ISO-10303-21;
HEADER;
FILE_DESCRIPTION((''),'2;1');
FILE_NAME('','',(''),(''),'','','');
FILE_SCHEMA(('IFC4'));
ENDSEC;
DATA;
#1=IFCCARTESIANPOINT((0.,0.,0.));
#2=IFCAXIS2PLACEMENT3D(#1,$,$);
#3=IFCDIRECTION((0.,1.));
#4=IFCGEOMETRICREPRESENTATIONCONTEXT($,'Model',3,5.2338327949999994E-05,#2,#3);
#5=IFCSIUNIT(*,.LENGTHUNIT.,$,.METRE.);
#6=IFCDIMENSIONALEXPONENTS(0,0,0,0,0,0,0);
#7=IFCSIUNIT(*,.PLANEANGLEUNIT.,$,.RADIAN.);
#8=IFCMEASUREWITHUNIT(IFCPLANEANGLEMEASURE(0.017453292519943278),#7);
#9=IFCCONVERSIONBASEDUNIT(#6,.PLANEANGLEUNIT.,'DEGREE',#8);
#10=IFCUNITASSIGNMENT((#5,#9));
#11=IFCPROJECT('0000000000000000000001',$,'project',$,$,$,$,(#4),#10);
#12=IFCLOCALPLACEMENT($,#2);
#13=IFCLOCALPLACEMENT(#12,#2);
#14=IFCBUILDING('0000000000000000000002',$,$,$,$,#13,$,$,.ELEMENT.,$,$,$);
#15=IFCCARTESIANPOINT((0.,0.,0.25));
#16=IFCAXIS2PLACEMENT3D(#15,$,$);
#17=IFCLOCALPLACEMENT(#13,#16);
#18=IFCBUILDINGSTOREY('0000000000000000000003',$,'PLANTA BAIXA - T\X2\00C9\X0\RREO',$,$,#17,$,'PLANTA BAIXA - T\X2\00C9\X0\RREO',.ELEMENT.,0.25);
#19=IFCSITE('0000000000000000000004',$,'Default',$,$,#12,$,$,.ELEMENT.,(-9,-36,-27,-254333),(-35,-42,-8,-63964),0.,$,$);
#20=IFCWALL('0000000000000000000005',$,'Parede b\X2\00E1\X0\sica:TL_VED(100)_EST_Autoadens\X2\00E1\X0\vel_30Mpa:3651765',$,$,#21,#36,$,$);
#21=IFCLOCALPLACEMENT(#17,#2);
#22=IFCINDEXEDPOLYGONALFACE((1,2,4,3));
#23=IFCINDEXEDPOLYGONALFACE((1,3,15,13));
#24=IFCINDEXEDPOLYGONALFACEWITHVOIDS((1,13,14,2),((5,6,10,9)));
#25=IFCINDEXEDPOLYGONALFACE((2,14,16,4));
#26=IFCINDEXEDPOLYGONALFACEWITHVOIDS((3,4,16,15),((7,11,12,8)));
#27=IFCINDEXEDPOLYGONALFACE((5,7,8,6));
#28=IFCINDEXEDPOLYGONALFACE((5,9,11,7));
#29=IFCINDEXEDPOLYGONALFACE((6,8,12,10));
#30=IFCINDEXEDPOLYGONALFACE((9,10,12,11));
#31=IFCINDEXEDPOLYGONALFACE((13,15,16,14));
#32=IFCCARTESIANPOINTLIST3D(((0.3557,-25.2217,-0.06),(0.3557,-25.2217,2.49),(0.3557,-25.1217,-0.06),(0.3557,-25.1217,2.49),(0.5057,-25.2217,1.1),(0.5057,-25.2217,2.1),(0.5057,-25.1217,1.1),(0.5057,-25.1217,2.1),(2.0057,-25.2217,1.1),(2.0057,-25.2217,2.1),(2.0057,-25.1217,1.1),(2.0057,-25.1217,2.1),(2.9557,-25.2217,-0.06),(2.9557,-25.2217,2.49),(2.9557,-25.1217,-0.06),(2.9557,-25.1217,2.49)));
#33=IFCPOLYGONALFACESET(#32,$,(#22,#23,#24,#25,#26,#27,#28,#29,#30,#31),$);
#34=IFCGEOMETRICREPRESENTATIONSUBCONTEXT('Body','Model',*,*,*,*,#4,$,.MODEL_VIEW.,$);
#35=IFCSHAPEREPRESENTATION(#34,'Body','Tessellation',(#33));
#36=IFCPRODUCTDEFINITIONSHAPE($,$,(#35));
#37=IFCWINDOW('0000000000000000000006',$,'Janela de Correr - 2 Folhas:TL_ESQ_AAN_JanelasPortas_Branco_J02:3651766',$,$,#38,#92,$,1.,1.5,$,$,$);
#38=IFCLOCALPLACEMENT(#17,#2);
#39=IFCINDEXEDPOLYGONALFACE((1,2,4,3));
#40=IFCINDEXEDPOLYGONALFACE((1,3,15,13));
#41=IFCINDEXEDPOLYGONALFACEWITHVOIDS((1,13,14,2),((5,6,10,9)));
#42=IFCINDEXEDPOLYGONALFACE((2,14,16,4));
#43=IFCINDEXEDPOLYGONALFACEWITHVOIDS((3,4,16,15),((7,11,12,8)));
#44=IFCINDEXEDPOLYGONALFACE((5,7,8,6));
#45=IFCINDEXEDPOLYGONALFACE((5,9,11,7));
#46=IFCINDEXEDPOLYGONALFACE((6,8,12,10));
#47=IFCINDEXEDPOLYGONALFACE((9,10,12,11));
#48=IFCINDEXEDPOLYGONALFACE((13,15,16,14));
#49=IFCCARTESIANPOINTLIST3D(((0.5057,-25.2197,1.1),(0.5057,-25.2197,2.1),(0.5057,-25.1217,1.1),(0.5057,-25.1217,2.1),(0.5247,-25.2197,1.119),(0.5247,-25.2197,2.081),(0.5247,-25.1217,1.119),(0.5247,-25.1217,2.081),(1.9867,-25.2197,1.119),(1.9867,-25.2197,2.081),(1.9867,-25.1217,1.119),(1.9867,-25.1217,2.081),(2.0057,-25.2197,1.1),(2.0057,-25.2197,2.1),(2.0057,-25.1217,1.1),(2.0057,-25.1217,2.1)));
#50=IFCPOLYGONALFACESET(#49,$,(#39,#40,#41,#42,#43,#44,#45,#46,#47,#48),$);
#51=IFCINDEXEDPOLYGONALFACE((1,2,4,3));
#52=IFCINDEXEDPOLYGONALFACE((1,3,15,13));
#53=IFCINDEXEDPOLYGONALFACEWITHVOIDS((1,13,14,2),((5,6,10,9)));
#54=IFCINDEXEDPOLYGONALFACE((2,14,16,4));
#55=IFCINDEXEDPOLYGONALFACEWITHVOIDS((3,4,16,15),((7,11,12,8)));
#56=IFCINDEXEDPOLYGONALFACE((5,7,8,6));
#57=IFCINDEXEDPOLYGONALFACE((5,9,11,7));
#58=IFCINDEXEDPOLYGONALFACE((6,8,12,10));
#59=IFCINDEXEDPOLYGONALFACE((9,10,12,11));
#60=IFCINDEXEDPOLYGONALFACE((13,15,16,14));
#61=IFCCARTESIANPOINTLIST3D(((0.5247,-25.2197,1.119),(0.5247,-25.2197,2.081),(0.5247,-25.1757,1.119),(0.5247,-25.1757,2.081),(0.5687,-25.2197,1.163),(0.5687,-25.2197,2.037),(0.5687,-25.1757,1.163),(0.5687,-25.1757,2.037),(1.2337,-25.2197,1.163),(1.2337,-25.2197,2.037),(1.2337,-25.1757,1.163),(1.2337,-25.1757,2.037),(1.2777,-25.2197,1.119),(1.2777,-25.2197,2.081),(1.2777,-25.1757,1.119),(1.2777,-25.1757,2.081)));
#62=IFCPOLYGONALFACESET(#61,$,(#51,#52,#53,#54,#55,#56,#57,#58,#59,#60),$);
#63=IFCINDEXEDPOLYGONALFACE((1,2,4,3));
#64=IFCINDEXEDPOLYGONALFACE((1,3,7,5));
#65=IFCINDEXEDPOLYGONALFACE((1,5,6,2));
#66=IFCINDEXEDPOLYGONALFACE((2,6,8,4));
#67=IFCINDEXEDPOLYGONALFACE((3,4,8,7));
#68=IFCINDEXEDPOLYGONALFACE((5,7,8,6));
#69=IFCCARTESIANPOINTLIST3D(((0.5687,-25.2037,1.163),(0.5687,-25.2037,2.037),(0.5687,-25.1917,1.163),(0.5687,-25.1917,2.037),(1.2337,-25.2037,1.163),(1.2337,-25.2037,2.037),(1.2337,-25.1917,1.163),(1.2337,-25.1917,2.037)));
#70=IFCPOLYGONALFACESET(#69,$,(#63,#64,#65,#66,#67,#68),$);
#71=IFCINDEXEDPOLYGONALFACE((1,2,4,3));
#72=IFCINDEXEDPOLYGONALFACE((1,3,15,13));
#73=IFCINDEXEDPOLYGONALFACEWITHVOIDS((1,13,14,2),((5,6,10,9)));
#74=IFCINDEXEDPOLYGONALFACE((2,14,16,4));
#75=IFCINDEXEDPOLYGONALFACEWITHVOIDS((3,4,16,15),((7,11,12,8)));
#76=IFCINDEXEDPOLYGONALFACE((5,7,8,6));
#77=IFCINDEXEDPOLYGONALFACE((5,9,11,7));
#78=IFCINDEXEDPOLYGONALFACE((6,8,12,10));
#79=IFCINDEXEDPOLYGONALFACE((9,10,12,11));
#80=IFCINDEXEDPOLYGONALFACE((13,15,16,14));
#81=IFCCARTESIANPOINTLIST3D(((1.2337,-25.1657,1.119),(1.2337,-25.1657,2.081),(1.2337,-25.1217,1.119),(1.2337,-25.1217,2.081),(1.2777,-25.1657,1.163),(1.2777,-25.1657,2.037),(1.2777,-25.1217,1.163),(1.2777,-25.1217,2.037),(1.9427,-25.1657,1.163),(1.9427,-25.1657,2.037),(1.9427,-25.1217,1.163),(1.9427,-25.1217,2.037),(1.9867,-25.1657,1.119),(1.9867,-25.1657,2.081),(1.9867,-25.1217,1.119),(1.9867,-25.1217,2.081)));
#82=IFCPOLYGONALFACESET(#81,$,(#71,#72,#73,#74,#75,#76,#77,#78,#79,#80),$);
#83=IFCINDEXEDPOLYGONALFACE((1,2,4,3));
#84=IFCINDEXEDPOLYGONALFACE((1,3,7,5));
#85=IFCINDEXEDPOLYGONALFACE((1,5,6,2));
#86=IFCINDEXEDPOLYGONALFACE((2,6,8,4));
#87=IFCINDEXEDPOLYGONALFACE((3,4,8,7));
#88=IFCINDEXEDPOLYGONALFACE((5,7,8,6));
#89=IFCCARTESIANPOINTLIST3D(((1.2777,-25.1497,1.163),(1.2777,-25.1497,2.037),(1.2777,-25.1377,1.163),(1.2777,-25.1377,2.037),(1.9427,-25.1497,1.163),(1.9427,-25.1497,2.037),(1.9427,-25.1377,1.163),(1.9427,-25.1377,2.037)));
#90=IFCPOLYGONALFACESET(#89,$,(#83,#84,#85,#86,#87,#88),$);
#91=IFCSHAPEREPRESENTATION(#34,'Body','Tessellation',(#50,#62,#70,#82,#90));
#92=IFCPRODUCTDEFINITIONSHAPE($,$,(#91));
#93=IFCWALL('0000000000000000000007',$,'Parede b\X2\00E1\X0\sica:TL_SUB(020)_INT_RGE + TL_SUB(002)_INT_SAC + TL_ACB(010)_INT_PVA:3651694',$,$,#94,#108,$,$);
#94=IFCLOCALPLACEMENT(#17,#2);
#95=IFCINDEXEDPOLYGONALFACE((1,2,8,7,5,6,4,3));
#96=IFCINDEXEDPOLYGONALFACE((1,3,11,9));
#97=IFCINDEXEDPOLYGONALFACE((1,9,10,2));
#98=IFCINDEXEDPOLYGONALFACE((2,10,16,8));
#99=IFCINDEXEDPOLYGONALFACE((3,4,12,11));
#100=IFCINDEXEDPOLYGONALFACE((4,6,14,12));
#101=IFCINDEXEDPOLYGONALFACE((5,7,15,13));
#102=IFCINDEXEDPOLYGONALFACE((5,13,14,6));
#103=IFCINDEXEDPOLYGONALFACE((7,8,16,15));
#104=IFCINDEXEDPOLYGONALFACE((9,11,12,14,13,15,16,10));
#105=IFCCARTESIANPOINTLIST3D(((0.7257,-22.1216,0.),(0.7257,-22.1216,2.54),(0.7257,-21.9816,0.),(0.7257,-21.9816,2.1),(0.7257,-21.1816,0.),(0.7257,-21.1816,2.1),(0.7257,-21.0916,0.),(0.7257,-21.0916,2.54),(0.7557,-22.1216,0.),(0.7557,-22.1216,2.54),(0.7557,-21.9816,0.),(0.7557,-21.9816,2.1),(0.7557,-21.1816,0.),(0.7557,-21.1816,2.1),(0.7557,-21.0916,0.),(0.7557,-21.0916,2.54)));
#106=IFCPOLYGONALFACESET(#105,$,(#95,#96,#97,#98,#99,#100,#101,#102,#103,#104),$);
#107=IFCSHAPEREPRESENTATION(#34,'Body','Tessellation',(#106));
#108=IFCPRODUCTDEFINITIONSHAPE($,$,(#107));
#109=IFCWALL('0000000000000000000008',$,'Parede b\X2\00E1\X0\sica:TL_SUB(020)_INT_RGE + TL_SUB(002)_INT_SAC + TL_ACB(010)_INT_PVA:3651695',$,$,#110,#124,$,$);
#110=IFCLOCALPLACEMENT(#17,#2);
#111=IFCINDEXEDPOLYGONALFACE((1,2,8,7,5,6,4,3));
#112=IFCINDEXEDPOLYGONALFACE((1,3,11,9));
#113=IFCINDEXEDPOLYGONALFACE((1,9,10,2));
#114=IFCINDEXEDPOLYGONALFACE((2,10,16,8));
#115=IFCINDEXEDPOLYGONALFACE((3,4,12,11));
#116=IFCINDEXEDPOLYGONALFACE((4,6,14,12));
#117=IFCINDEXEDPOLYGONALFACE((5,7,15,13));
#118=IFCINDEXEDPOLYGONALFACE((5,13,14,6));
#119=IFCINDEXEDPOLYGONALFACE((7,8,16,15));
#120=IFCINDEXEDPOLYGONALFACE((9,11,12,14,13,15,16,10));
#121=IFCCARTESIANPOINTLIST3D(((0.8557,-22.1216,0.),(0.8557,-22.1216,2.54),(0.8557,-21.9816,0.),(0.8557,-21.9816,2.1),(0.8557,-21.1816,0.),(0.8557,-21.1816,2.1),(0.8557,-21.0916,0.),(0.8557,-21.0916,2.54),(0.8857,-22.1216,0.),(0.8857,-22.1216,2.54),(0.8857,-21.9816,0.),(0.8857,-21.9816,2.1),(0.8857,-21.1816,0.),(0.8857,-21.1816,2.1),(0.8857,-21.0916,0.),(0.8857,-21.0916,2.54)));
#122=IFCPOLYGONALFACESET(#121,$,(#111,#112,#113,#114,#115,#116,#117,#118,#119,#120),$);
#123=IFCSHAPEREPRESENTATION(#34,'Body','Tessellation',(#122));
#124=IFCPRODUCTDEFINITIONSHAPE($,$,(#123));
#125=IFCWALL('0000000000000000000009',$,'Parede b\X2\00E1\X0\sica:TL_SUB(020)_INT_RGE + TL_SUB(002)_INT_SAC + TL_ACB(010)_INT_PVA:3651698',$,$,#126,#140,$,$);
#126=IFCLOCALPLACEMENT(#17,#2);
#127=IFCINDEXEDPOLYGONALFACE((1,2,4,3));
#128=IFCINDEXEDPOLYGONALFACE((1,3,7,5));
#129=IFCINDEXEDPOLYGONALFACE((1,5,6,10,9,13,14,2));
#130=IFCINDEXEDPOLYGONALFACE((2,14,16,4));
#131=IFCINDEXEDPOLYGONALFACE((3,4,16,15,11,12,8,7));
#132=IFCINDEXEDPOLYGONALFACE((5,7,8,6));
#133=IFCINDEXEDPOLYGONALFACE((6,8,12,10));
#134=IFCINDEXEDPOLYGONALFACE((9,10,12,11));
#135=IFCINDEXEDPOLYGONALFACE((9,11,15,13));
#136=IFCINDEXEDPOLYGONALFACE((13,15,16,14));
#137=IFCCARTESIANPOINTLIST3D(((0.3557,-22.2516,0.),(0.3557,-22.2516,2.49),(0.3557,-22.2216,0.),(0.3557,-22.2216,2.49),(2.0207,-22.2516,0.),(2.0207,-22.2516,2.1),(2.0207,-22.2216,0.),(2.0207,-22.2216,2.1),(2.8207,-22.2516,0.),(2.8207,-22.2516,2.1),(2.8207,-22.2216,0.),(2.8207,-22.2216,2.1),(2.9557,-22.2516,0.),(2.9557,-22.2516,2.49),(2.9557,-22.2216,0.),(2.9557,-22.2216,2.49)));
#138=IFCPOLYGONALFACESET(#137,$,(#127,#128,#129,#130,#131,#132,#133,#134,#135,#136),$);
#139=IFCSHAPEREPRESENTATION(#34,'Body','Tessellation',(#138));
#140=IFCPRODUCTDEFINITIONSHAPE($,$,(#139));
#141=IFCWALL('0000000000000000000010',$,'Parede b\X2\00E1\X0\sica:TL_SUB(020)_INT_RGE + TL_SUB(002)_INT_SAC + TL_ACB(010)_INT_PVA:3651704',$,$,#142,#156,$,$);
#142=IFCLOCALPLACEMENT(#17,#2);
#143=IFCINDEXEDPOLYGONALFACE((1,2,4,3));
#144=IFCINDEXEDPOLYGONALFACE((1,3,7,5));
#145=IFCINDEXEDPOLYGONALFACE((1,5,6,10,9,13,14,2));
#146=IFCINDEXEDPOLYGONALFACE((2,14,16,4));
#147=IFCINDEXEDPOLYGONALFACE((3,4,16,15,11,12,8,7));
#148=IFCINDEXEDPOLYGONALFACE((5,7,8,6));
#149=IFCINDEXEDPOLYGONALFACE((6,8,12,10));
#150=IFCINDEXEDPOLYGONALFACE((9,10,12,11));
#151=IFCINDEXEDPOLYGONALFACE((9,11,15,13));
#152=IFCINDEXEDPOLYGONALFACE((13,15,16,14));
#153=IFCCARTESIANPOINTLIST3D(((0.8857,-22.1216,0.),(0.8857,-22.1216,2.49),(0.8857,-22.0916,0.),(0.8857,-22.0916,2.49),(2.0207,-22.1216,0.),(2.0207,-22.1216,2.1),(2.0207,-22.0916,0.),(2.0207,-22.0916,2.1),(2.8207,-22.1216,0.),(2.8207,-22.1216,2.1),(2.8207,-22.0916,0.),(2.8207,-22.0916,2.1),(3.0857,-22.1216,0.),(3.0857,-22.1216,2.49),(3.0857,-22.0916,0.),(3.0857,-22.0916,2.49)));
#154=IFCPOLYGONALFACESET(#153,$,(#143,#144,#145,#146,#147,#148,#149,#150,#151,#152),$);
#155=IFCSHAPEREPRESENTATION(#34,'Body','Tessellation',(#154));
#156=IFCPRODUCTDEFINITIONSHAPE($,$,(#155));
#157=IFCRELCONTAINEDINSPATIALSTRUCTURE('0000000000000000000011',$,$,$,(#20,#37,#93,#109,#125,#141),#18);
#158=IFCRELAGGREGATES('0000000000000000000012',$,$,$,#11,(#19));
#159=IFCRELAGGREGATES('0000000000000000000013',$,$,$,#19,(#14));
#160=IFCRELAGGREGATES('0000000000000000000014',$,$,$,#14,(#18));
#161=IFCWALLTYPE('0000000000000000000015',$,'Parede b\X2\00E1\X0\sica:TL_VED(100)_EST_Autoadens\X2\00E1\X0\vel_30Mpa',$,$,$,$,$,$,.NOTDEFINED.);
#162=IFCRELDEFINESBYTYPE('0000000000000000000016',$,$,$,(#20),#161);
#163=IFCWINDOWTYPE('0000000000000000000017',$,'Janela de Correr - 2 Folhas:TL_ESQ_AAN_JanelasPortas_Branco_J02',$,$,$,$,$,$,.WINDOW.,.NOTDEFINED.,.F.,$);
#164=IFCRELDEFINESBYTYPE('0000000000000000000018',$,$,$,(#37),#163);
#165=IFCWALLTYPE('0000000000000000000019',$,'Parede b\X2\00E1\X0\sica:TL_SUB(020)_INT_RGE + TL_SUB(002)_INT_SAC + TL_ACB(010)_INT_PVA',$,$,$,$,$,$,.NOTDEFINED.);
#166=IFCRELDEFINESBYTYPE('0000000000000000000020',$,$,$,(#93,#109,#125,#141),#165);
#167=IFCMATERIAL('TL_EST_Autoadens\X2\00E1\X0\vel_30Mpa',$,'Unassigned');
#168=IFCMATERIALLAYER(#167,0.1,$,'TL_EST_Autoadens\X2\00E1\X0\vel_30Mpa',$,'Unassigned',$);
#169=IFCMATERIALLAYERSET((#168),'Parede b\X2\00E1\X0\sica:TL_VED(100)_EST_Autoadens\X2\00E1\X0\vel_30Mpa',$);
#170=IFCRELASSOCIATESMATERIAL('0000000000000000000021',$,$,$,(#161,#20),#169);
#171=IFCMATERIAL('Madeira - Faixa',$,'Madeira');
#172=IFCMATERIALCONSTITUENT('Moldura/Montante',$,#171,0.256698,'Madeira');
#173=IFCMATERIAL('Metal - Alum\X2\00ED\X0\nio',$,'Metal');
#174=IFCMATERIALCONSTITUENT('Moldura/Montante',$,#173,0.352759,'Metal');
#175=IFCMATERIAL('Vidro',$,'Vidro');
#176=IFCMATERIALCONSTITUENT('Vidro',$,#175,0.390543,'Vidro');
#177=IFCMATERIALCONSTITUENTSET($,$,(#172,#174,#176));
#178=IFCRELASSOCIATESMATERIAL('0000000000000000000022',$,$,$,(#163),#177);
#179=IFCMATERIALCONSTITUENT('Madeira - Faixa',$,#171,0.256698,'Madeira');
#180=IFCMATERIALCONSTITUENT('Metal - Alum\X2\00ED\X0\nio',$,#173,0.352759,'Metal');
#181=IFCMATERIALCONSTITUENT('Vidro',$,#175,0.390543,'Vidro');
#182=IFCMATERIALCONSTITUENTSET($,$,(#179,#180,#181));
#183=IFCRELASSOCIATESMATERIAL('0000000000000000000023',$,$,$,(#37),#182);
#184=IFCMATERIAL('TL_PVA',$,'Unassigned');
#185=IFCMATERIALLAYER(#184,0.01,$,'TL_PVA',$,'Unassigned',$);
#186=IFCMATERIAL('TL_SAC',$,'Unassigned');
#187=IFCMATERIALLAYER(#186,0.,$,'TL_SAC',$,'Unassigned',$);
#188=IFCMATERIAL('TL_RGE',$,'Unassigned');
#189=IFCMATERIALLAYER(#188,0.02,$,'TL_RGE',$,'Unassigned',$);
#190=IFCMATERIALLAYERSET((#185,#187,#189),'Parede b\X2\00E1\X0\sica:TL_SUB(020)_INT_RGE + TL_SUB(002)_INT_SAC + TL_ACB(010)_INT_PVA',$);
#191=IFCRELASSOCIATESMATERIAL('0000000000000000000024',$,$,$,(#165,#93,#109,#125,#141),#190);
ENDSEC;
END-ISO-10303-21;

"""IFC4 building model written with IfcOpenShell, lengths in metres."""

from ifc_helpers import new_model, entity, si_unit, converted_unit, direction, frame, frame_2d, origin, origin_2d_with_axis, place, context, subcontext, project, spatial, polyline, rectangle, outline, extrude, source, transform, mapped, material, layer, layer_set, layer_usage, constituent, constituent_set, type_object, type_shapes, element, fill, save


model = new_model("IFC4")

# Units and contexts
model_context = context("Model", 3, precision=5.2338327949999994e-05, world=origin(), true_north=direction((0.0, 1.0)))
body_context = subcontext(model_context, "Body", "Model", "MODEL_VIEW")
ifc_project = project(units=[si_unit("LENGTHUNIT", "METRE"), converted_unit("PLANEANGLEUNIT", "DEGREE", entity("IfcPlaneAngleMeasure", 0.017453292519943278), si_unit("PLANEANGLEUNIT", "RADIAN"), dimensions=[0, 0, 0, 0, 0, 0, 0])], contexts=[model_context])

# Site, building, storey
site_placement = place(None, frame((0.0, 0.0, 0.0)))
site = spatial("IfcSite", under=ifc_project, at=site_placement, Name="Default", CompositionType="ELEMENT", RefLatitude=(-9, -36, -27, -254333), RefLongitude=(-35, -42, -8, -63964), RefElevation=0.0)
building_placement = place(site_placement, origin())
building = spatial("IfcBuilding", under=site, at=building_placement, CompositionType="ELEMENT")
storey_placement = place(building_placement, frame((0.0, 0.0, 0.25)))
storey = spatial("IfcBuildingStorey", under=building, at=storey_placement, Name="PLANTA BAIXA - TÉRREO", LongName="PLANTA BAIXA - TÉRREO", CompositionType="ELEMENT", Elevation=0.25)

# Shared definitions
ifc_material_1 = material(Name="TL_EST_Autoadensável_30Mpa", Category="Unassigned")
ifc_layer_1 = layer(ifc_material_1, 0.1, Name="TL_EST_Autoadensável_30Mpa", Category="Unassigned")
ifc_layer_set_1 = layer_set([ifc_layer_1], Name="Parede básica:TL_VED(100)_EST_Autoadensável_30Mpa")
wall_type_1 = type_object("IfcWallType", Name="Parede básica:TL_VED(100)_EST_Autoadensável_30Mpa", PredefinedType="NOTDEFINED", material=ifc_layer_set_1)

# Shared definitions
ifc_material_2 = material(Name="Vidro", Category="Vidro")

# Wall, opening, window
ifc_layer_usage_1 = layer_usage(ifc_layer_set_1, "AXIS2", "POSITIVE", -0.05)
wall_1_placement = place(storey_placement, frame((0.3557, -25.1717, -0.06)))
wall_1 = element("IfcWall", 1, at=wall_1_placement, inside=storey, type_object=wall_type_1, material=ifc_layer_usage_1, Name="Parede básica:TL_VED(100)_EST_Autoadensável_30Mpa:3651765", context=body_context, shape_type="SweptSolid", body=[
    extrude(rectangle(XDim=2.6, YDim=0.1, at=frame_2d((1.3, 0.0), x_axis=(-1.0, 0.0))), origin(), (0.0, 0.0, 1.0), 2.55),
])
opening_1_placement = place(wall_1_placement, frame((1.65, 0.05, 1.16)))
opening_1 = element("IfcOpeningElement", 2, at=opening_1_placement, cuts=wall_1, PredefinedType="OPENING", context=body_context, shape_type="SweptSolid", body=[
    extrude(rectangle(XDim=1.0, YDim=1.5, at=frame_2d((0.5, 0.75), x_axis=(-1.0, 0.0))), frame((0.0, 0.0, 0.0), z_axis=(0.0, -1.0, 0.0), x_axis=(0.0, 0.0, 1.0)), (0.0, 0.0, 1.0), 0.1),
])
ifc_material_3 = material(Name="Madeira - Faixa", Category="Madeira")
ifc_constituent_1 = constituent(ifc_material_3, Name="Madeira - Faixa", Category="Madeira", fraction=0.256698)
ifc_material_4 = material(Name="Metal - Alumínio", Category="Metal")
ifc_constituent_2 = constituent(ifc_material_4, Name="Metal - Alumínio", Category="Metal", fraction=0.352759)
ifc_constituent_3 = constituent(ifc_material_2, Name="Vidro", Category="Vidro", fraction=0.390543)
ifc_constituent_set_1 = constituent_set(constituents=[ifc_constituent_1, ifc_constituent_2, ifc_constituent_3])
ifc_constituent_4 = constituent(ifc_material_3, Name="Moldura/Montante", Category="Madeira", fraction=0.256698)
ifc_constituent_5 = constituent(ifc_material_4, Name="Moldura/Montante", Category="Metal", fraction=0.352759)
ifc_constituent_6 = constituent(ifc_material_2, Name="Vidro", Category="Vidro", fraction=0.390543)
ifc_constituent_set_2 = constituent_set(constituents=[ifc_constituent_4, ifc_constituent_5, ifc_constituent_6])
window_type = type_object("IfcWindowType", Name="Janela de Correr - 2 Folhas:TL_ESQ_AAN_JanelasPortas_Branco_J02", ParameterTakesPrecedence=False, PartitioningType="NOTDEFINED", PredefinedType="WINDOW", material=ifc_constituent_set_2)
shared_shape_1 = source(origin(), body_context, "Body", "SweptSolid", [
    extrude(outline(polyline([(-0.75, -0.5), (0.75, -0.5), (0.75, 0.5), (-0.75, 0.5), (-0.75, -0.5)]), holes=[polyline([(-0.731, -0.481), (-0.731, 0.481), (0.731, 0.481), (0.731, -0.481), (-0.731, -0.481)])]), frame((0.75, 0.0, 0.5), z_axis=(0.0, 1.0, 0.0), x_axis=(1.0, 0.0, 0.0)), (0.0, 0.0, 1.0), 0.098),
    extrude(outline(polyline([(-0.3765, -0.481), (0.3765, -0.481), (0.3765, 0.481), (-0.3765, 0.481), (-0.3765, -0.481)]), holes=[polyline([(-0.3325, -0.437), (-0.3325, 0.437), (0.3325, 0.437), (0.3325, -0.437), (-0.3325, -0.437)])]), frame((1.1045, 0.054, 0.5), z_axis=(0.0, 1.0, 0.0), x_axis=(1.0, 0.0, 0.0)), (0.0, 0.0, 1.0), 0.044),
    extrude(rectangle(XDim=0.012, YDim=0.665, at=origin_2d_with_axis()), frame((1.1045, 0.076, 0.063), z_axis=(0.0, 0.0, 1.0), x_axis=(0.0, -1.0, 0.0)), (0.0, 0.0, 1.0), 0.874),
    extrude(outline(polyline([(-0.481, -0.3765), (0.481, -0.3765), (0.481, 0.3765), (-0.481, 0.3765), (-0.481, -0.3765)]), holes=[polyline([(-0.437, -0.3325), (-0.437, 0.3325), (0.437, 0.3325), (0.437, -0.3325), (-0.437, -0.3325)])]), frame((0.3955, 0.0, 0.5), z_axis=(0.0, 1.0, 0.0), x_axis=(0.0, 0.0, -1.0)), (0.0, 0.0, 1.0), 0.044),
    extrude(rectangle(XDim=0.012, YDim=0.665, at=origin_2d_with_axis()), frame((0.3955, 0.022, 0.063), z_axis=(0.0, 0.0, 1.0), x_axis=(0.0, -1.0, 0.0)), (0.0, 0.0, 1.0), 0.874),
])
type_shapes(window_type, [shared_shape_1])
window_placement = place(opening_1_placement, frame((0.0, 0.0, 0.0), z_axis=(0.0, 0.0, 1.0), x_axis=(-1.0, 0.0, 0.0)))
window = element("IfcWindow", 3, at=window_placement, inside=storey, type_object=window_type, material=ifc_constituent_set_1, Name="Janela de Correr - 2 Folhas:TL_ESQ_AAN_JanelasPortas_Branco_J02:3651766", OverallHeight=1.0, OverallWidth=1.5, context=body_context, shape_type="MappedRepresentation", body=[
    mapped(shared_shape_1, transform((0.0, 0.0, 0.0), scale=1.0)),
])
fill(opening_1, window)

# Walls, openings
ifc_material_5 = material(Name="TL_PVA", Category="Unassigned")
ifc_layer_2 = layer(ifc_material_5, 0.01, Name="TL_PVA", Category="Unassigned")
ifc_material_6 = material(Name="TL_SAC", Category="Unassigned")
ifc_layer_3 = layer(ifc_material_6, 0.0, Name="TL_SAC", Category="Unassigned")
ifc_material_7 = material(Name="TL_RGE", Category="Unassigned")
ifc_layer_4 = layer(ifc_material_7, 0.02, Name="TL_RGE", Category="Unassigned")
ifc_layer_set_2 = layer_set([ifc_layer_2, ifc_layer_3, ifc_layer_4], Name="Parede básica:TL_SUB(020)_INT_RGE + TL_SUB(002)_INT_SAC + TL_ACB(010)_INT_PVA")
ifc_layer_usage_2 = layer_usage(ifc_layer_set_2, "AXIS2", "NEGATIVE", 0.015)
wall_type_2 = type_object("IfcWallType", Name="Parede básica:TL_SUB(020)_INT_RGE + TL_SUB(002)_INT_SAC + TL_ACB(010)_INT_PVA", PredefinedType="NOTDEFINED", material=ifc_layer_set_2)
wall_2_placement = place(storey_placement, frame((0.7407, -22.1216, 0.0), z_axis=(0.0, 0.0, 1.0), x_axis=(0.0, 1.0, 0.0)))
wall_2 = element("IfcWall", 4, at=wall_2_placement, inside=storey, type_object=wall_type_2, material=ifc_layer_usage_2, Name="Parede básica:TL_SUB(020)_INT_RGE + TL_SUB(002)_INT_SAC + TL_ACB(010)_INT_PVA:3651694", context=body_context, shape_type="SweptSolid", body=[
    extrude(rectangle(XDim=1.03, YDim=0.03, at=frame_2d((0.515, 0.0), x_axis=(1.0, 0.0))), origin(), (0.0, 0.0, 1.0), 2.54),
])
opening_2_placement = place(wall_2_placement, frame((22.1216, 0.7407, 0.0)))
element("IfcOpeningElement", 5, at=opening_2_placement, cuts=wall_2, PredefinedType="OPENING", context=body_context, shape_type="SweptSolid", body=[
    extrude(rectangle(XDim=2.1, YDim=0.8, at=frame_2d((0.0, 0.0), x_axis=(0.0, 1.0))), frame((-21.5816, -2.3797, 1.05), z_axis=(0.0, 1.0, 0.0), x_axis=(-1.0, 0.0, 0.0)), (0.0, 0.0, 1.0), 3.048),
])
ifc_layer_usage_3 = layer_usage(ifc_layer_set_2, "AXIS2", "NEGATIVE", 0.015)
wall_3_placement = place(storey_placement, frame((0.8707, -21.0916, 0.0), z_axis=(0.0, 0.0, 1.0), x_axis=(0.0, -1.0, 0.0)))
wall_3 = element("IfcWall", 6, at=wall_3_placement, inside=storey, type_object=wall_type_2, material=ifc_layer_usage_3, Name="Parede básica:TL_SUB(020)_INT_RGE + TL_SUB(002)_INT_SAC + TL_ACB(010)_INT_PVA:3651695", context=body_context, shape_type="SweptSolid", body=[
    extrude(rectangle(XDim=1.03, YDim=0.03, at=frame_2d((0.515, 0.0), x_axis=(1.0, 0.0))), origin(), (0.0, 0.0, 1.0), 2.54),
])
opening_3_placement = place(wall_3_placement, frame((-21.0916, -0.8707, 0.0)))
element("IfcOpeningElement", 7, at=opening_3_placement, cuts=wall_3, PredefinedType="OPENING", context=body_context, shape_type="SweptSolid", body=[
    extrude(rectangle(XDim=2.1, YDim=0.8, at=frame_2d((0.0, 0.0), x_axis=(1.0, 0.0))), frame((21.5816, -0.6683, 1.05), z_axis=(0.0, 1.0, 0.0), x_axis=(0.0, 0.0, 1.0)), (0.0, 0.0, 1.0), 3.048),
])
ifc_layer_usage_4 = layer_usage(ifc_layer_set_2, "AXIS2", "NEGATIVE", 0.015)
wall_4_placement = place(storey_placement, frame((2.9557, -22.2366, 0.0), z_axis=(0.0, 0.0, 1.0), x_axis=(-1.0, 0.0, 0.0)))
wall_4 = element("IfcWall", 8, at=wall_4_placement, inside=storey, type_object=wall_type_2, material=ifc_layer_usage_4, Name="Parede básica:TL_SUB(020)_INT_RGE + TL_SUB(002)_INT_SAC + TL_ACB(010)_INT_PVA:3651698", context=body_context, shape_type="SweptSolid", body=[
    extrude(rectangle(XDim=2.6, YDim=0.03, at=frame_2d((1.3, 0.0), x_axis=(1.0, 0.0))), origin(), (0.0, 0.0, 1.0), 2.49),
])
opening_4_placement = place(wall_4_placement, frame((2.9557, -22.2366, 0.0)))
element("IfcOpeningElement", 9, at=opening_4_placement, cuts=wall_4, PredefinedType="OPENING", context=body_context, shape_type="SweptSolid", body=[
    extrude(rectangle(XDim=2.1, YDim=0.8, at=frame_2d((0.0, 0.0), x_axis=(1.0, 0.0))), frame((-2.4207, 20.5976, 1.05), z_axis=(0.0, 1.0, 0.0), x_axis=(0.0, 0.0, 1.0)), (0.0, 0.0, 1.0), 3.048),
])
ifc_layer_usage_5 = layer_usage(ifc_layer_set_2, "AXIS2", "NEGATIVE", 0.015)
wall_5_placement = place(storey_placement, frame((0.8857, -22.1066, 0.0)))
wall_5 = element("IfcWall", 10, at=wall_5_placement, inside=storey, type_object=wall_type_2, material=ifc_layer_usage_5, Name="Parede básica:TL_SUB(020)_INT_RGE + TL_SUB(002)_INT_SAC + TL_ACB(010)_INT_PVA:3651704", context=body_context, shape_type="SweptSolid", body=[
    extrude(rectangle(XDim=2.2, YDim=0.03, at=frame_2d((1.1, 0.0), x_axis=(1.0, 0.0))), origin(), (0.0, 0.0, 1.0), 2.49),
])
opening_5_placement = place(wall_5_placement, frame((-0.8857, 22.1066, 0.0)))
element("IfcOpeningElement", 11, at=opening_5_placement, cuts=wall_5, PredefinedType="OPENING", context=body_context, shape_type="SweptSolid", body=[
    extrude(rectangle(XDim=2.1, YDim=0.8, at=frame_2d((0.0, 0.0), x_axis=(0.0, 1.0))), frame((2.4207, -23.6456, 1.05), z_axis=(0.0, 1.0, 0.0), x_axis=(-1.0, 0.0, 0.0)), (0.0, 0.0, 1.0), 3.048),
])

save(model, "model.ifc")
